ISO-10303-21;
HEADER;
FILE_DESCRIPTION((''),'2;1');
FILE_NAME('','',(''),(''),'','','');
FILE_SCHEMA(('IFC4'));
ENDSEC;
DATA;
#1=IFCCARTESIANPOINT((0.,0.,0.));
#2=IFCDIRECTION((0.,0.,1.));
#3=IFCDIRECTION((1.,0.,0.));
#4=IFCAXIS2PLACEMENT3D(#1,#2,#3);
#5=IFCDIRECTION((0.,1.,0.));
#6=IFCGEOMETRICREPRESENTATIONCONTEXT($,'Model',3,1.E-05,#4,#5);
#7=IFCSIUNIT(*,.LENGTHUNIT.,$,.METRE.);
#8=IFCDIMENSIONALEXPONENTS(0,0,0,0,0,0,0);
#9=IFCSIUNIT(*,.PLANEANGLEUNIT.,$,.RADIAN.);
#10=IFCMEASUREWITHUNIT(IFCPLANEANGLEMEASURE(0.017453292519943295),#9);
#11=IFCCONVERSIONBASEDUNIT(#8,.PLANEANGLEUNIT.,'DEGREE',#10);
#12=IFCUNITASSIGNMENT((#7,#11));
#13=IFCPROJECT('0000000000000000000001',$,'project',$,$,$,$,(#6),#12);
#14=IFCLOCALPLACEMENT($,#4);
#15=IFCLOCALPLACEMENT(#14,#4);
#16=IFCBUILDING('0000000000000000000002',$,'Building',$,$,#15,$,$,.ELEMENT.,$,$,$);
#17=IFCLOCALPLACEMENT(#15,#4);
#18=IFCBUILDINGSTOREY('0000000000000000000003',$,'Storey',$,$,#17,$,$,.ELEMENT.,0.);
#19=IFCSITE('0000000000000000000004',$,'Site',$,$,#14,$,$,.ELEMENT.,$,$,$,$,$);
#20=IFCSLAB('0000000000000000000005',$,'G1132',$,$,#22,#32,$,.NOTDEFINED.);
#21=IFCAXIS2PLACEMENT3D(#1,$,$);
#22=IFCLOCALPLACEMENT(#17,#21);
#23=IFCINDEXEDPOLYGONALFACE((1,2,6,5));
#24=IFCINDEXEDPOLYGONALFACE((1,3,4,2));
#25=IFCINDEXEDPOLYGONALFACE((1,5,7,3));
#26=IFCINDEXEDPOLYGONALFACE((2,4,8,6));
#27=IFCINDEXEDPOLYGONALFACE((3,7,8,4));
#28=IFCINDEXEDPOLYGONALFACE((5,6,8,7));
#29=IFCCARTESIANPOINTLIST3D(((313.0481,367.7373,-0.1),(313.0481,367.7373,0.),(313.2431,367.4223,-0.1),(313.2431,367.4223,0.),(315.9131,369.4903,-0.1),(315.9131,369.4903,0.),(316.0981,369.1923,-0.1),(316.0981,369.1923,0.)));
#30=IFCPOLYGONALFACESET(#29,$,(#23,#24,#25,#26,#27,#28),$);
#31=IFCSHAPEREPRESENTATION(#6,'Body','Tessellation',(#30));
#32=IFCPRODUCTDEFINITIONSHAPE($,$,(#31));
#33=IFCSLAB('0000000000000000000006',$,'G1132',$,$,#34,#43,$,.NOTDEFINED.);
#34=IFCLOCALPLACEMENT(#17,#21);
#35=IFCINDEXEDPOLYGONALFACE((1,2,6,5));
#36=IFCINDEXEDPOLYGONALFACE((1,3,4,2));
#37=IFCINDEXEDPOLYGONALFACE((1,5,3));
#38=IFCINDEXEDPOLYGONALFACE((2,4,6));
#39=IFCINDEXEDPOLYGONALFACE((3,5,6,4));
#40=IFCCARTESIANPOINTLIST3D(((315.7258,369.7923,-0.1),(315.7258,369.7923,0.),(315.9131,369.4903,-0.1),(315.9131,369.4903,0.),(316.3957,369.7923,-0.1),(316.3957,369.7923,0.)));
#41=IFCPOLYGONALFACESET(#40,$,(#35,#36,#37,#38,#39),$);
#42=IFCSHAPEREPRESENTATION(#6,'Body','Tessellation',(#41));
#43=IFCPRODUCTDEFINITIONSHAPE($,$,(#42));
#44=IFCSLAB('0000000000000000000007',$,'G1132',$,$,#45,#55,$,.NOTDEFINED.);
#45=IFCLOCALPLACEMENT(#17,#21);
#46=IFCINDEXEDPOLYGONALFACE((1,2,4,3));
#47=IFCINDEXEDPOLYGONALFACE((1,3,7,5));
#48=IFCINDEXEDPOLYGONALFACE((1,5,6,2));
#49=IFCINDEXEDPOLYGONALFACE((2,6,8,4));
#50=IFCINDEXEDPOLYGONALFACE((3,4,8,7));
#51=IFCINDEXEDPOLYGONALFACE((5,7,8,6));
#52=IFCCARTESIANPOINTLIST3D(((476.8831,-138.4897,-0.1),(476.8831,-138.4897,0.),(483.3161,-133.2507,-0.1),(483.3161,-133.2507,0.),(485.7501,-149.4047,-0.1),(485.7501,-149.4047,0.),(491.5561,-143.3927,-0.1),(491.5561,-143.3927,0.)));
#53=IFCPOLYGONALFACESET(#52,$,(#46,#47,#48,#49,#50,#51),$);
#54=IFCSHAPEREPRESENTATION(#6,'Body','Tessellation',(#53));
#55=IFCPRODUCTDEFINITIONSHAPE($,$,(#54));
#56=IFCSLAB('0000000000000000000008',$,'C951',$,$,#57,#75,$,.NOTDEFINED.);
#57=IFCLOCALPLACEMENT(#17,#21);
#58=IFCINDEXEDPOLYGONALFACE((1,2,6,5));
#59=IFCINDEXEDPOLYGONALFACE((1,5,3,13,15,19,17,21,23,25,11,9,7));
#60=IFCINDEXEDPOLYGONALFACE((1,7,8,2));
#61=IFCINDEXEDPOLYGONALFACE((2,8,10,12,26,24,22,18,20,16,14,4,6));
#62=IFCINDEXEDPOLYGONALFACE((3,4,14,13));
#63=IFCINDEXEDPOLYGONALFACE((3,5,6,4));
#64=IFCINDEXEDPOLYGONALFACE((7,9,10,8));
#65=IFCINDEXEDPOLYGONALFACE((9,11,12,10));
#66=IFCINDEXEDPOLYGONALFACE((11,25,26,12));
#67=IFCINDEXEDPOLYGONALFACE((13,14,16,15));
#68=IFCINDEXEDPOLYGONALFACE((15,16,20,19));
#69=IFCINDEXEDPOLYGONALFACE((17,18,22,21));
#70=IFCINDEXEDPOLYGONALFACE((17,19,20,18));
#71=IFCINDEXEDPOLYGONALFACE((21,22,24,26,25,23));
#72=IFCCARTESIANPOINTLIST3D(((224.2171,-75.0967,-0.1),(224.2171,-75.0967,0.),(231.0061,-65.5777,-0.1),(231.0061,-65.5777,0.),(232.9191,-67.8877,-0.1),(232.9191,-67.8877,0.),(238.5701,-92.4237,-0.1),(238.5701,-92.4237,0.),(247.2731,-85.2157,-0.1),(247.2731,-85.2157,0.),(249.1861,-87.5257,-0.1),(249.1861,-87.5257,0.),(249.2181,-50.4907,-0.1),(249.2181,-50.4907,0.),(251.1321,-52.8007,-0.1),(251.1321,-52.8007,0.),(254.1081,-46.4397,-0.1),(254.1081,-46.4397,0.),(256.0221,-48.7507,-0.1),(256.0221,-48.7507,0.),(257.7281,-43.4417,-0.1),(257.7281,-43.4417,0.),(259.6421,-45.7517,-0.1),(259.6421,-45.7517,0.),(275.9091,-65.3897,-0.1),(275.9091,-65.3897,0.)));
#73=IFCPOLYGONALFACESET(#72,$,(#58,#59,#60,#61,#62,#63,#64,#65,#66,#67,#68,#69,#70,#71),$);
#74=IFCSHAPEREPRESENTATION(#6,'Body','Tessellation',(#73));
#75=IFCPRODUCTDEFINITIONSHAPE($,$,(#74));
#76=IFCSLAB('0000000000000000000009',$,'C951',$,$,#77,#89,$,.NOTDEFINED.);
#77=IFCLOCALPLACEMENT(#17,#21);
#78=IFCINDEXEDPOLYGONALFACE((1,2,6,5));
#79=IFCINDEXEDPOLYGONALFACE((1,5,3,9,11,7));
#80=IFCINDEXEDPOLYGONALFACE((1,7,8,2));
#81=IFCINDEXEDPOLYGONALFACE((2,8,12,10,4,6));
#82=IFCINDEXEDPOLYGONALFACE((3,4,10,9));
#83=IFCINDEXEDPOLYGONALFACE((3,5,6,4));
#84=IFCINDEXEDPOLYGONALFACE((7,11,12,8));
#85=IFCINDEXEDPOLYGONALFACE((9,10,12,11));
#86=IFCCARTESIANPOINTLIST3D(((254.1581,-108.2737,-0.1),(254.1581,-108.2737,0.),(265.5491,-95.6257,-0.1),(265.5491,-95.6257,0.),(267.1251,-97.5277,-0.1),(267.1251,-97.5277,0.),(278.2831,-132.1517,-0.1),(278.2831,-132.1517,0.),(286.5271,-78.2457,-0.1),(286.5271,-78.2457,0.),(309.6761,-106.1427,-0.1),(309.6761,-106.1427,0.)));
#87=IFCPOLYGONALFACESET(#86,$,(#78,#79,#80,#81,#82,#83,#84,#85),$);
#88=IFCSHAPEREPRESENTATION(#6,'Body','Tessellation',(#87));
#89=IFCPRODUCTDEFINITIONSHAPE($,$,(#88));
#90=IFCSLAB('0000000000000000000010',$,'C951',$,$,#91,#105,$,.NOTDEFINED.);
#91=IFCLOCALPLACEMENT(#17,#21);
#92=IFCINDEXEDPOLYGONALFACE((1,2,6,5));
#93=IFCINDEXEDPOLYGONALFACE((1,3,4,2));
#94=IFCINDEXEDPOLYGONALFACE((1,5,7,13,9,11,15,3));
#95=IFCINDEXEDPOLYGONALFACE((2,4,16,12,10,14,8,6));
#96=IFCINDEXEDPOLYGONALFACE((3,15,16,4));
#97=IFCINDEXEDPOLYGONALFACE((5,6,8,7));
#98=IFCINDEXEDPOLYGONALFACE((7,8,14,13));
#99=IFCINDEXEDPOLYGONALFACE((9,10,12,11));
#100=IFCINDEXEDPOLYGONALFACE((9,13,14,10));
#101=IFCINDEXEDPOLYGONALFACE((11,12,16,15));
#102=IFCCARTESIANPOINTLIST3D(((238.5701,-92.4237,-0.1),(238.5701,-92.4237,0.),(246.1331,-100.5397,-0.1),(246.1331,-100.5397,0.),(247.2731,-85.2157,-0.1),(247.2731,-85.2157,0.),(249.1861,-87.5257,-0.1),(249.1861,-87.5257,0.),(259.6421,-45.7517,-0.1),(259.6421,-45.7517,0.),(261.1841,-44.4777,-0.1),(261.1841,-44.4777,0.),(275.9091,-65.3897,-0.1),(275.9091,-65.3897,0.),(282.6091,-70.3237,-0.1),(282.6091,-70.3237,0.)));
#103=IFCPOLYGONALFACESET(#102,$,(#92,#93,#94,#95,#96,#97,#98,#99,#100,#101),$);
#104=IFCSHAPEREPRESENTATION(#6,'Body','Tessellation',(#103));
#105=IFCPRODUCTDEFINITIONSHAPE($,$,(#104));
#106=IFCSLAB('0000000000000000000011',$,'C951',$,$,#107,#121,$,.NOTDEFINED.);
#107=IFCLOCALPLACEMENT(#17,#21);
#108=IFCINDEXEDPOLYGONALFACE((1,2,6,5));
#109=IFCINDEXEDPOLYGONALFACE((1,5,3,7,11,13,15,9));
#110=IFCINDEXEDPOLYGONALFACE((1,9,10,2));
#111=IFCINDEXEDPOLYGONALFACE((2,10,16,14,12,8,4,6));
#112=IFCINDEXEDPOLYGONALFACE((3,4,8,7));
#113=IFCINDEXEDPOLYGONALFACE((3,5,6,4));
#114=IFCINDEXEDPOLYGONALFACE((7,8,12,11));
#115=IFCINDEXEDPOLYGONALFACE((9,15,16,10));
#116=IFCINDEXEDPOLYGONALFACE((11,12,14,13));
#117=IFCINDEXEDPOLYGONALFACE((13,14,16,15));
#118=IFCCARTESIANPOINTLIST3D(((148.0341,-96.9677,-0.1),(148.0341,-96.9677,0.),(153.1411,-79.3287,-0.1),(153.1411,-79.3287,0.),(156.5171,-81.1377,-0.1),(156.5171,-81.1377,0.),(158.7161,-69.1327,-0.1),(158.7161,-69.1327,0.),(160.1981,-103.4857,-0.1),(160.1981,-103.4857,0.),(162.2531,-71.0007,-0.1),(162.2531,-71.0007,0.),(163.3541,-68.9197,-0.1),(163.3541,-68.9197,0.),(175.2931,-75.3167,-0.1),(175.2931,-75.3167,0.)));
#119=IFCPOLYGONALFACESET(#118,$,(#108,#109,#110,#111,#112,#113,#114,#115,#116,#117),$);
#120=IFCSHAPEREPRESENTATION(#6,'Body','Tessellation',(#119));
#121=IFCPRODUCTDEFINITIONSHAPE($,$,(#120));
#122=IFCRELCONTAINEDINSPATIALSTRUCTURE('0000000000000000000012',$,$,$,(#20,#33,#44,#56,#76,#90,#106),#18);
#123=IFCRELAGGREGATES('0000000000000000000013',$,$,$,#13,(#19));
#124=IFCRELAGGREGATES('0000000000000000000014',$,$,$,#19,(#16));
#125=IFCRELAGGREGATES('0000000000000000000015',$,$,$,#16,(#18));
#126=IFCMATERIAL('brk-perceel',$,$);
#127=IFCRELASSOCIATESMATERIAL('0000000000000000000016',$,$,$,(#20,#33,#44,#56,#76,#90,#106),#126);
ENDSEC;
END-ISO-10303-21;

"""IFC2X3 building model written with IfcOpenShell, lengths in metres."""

from ifc_helpers import new_model, entity, si_unit, converted_unit, direction, frame, origin_with_axes, place, context, project, spatial, polyline, outline, extrude, material, element, save


model = new_model("IFC2X3")

# Units and contexts
model_context = context("Model", 3, precision=1e-05, world=origin_with_axes(), true_north=direction((0.0, 1.0, 0.0)))
ifc_project = project(units=[si_unit("LENGTHUNIT", "METRE"), converted_unit("PLANEANGLEUNIT", "DEGREE", entity("IfcPlaneAngleMeasure", 0.017453292519943295), si_unit("PLANEANGLEUNIT", "RADIAN"), dimensions=[0, 0, 0, 0, 0, 0, 0])], contexts=[model_context])

# Site, building, storey
site_placement = place(None, origin_with_axes())
site = spatial("IfcSite", under=ifc_project, at=site_placement, Name="Site", CompositionType="ELEMENT")
building_placement = place(site_placement, origin_with_axes())
building = spatial("IfcBuilding", under=site, at=building_placement, Name="Building", CompositionType="ELEMENT")
storey_placement = place(building_placement, origin_with_axes())
storey = spatial("IfcBuildingStorey", under=building, at=storey_placement, Name="Storey", CompositionType="ELEMENT", Elevation=0.0)

# Slabs
ifc_material_1 = material(Name="brk-perceel")
slab_1_placement = place(storey_placement, frame((0.0, 0.0, -0.1), z_axis=(0.0, 0.0, 1.0), x_axis=(1.0, 0.0, 0.0)))
element("IfcSlab", 1, at=slab_1_placement, inside=storey, material=ifc_material_1, Name="G1132", PredefinedType="NOTDEFINED", context=model_context, shape_type="SweptSolid", body=[
    extrude(outline(polyline([(316.0981, 369.1923), (313.2431, 367.4223), (313.0481, 367.7373), (315.9131, 369.4903), (316.0981, 369.1923)])), origin_with_axes(), (0.0, 0.0, 1.0), 0.1),
])
slab_2_placement = place(storey_placement, frame((0.0, 0.0, -0.1), z_axis=(0.0, 0.0, 1.0), x_axis=(1.0, 0.0, 0.0)))
element("IfcSlab", 2, at=slab_2_placement, inside=storey, material=ifc_material_1, Name="G1132", PredefinedType="NOTDEFINED", context=model_context, shape_type="SweptSolid", body=[
    extrude(outline(polyline([(315.9131, 369.4903), (315.7258, 369.7923), (316.3957, 369.7923), (315.9131, 369.4903)])), origin_with_axes(), (0.0, 0.0, 1.0), 0.1),
])
slab_3_placement = place(storey_placement, frame((0.0, 0.0, -0.1), z_axis=(0.0, 0.0, 1.0), x_axis=(1.0, 0.0, 0.0)))
element("IfcSlab", 3, at=slab_3_placement, inside=storey, material=ifc_material_1, Name="G1132", PredefinedType="NOTDEFINED", context=model_context, shape_type="SweptSolid", body=[
    extrude(outline(polyline([(485.7501, -149.4047), (476.8831, -138.4897), (483.3161, -133.2507), (491.5561, -143.3927), (485.7501, -149.4047)])), origin_with_axes(), (0.0, 0.0, 1.0), 0.1),
])
slab_4_placement = place(storey_placement, frame((0.0, 0.0, -0.1), z_axis=(0.0, 0.0, 1.0), x_axis=(1.0, 0.0, 0.0)))
element("IfcSlab", 4, at=slab_4_placement, inside=storey, material=ifc_material_1, Name="C951", PredefinedType="NOTDEFINED", context=model_context, shape_type="SweptSolid", body=[
    extrude(outline(polyline([(224.2171, -75.0967), (232.9191, -67.8877), (231.0061, -65.5777), (249.2181, -50.4907), (251.1321, -52.8007), (256.0221, -48.7507), (254.1081, -46.4397), (257.7281, -43.4417), (259.6421, -45.7517), (275.9091, -65.3897), (249.1861, -87.5257), (247.2731, -85.2157), (238.5701, -92.4237), (224.2171, -75.0967)])), origin_with_axes(), (0.0, 0.0, 1.0), 0.1),
])
slab_5_placement = place(storey_placement, frame((0.0, 0.0, -0.1), z_axis=(0.0, 0.0, 1.0), x_axis=(1.0, 0.0, 0.0)))
element("IfcSlab", 5, at=slab_5_placement, inside=storey, material=ifc_material_1, Name="C951", PredefinedType="NOTDEFINED", context=model_context, shape_type="SweptSolid", body=[
    extrude(outline(polyline([(267.1251, -97.5277), (265.5491, -95.6257), (286.5271, -78.2457), (309.6761, -106.1427), (278.2831, -132.1517), (254.1581, -108.2737), (267.1251, -97.5277)])), origin_with_axes(), (0.0, 0.0, 1.0), 0.1),
])
slab_6_placement = place(storey_placement, frame((0.0, 0.0, -0.1), z_axis=(0.0, 0.0, 1.0), x_axis=(1.0, 0.0, 0.0)))
element("IfcSlab", 6, at=slab_6_placement, inside=storey, material=ifc_material_1, Name="C951", PredefinedType="NOTDEFINED", context=model_context, shape_type="SweptSolid", body=[
    extrude(outline(polyline([(246.1331, -100.5397), (238.5701, -92.4237), (247.2731, -85.2157), (249.1861, -87.5257), (275.9091, -65.3897), (259.6421, -45.7517), (261.1841, -44.4777), (282.6091, -70.3237), (246.1331, -100.5397)])), origin_with_axes(), (0.0, 0.0, 1.0), 0.1),
])
slab_7_placement = place(storey_placement, frame((0.0, 0.0, -0.1), z_axis=(0.0, 0.0, 1.0), x_axis=(1.0, 0.0, 0.0)))
element("IfcSlab", 7, at=slab_7_placement, inside=storey, material=ifc_material_1, Name="C951", PredefinedType="NOTDEFINED", context=model_context, shape_type="SweptSolid", body=[
    extrude(outline(polyline([(175.2931, -75.3167), (160.1981, -103.4857), (148.0341, -96.9677), (156.5171, -81.1377), (153.1411, -79.3287), (158.7161, -69.1327), (162.2531, -71.0007), (163.3541, -68.9197), (175.2931, -75.3167)])), origin_with_axes(), (0.0, 0.0, 1.0), 0.1),
])

save(model, "model.ifc")
